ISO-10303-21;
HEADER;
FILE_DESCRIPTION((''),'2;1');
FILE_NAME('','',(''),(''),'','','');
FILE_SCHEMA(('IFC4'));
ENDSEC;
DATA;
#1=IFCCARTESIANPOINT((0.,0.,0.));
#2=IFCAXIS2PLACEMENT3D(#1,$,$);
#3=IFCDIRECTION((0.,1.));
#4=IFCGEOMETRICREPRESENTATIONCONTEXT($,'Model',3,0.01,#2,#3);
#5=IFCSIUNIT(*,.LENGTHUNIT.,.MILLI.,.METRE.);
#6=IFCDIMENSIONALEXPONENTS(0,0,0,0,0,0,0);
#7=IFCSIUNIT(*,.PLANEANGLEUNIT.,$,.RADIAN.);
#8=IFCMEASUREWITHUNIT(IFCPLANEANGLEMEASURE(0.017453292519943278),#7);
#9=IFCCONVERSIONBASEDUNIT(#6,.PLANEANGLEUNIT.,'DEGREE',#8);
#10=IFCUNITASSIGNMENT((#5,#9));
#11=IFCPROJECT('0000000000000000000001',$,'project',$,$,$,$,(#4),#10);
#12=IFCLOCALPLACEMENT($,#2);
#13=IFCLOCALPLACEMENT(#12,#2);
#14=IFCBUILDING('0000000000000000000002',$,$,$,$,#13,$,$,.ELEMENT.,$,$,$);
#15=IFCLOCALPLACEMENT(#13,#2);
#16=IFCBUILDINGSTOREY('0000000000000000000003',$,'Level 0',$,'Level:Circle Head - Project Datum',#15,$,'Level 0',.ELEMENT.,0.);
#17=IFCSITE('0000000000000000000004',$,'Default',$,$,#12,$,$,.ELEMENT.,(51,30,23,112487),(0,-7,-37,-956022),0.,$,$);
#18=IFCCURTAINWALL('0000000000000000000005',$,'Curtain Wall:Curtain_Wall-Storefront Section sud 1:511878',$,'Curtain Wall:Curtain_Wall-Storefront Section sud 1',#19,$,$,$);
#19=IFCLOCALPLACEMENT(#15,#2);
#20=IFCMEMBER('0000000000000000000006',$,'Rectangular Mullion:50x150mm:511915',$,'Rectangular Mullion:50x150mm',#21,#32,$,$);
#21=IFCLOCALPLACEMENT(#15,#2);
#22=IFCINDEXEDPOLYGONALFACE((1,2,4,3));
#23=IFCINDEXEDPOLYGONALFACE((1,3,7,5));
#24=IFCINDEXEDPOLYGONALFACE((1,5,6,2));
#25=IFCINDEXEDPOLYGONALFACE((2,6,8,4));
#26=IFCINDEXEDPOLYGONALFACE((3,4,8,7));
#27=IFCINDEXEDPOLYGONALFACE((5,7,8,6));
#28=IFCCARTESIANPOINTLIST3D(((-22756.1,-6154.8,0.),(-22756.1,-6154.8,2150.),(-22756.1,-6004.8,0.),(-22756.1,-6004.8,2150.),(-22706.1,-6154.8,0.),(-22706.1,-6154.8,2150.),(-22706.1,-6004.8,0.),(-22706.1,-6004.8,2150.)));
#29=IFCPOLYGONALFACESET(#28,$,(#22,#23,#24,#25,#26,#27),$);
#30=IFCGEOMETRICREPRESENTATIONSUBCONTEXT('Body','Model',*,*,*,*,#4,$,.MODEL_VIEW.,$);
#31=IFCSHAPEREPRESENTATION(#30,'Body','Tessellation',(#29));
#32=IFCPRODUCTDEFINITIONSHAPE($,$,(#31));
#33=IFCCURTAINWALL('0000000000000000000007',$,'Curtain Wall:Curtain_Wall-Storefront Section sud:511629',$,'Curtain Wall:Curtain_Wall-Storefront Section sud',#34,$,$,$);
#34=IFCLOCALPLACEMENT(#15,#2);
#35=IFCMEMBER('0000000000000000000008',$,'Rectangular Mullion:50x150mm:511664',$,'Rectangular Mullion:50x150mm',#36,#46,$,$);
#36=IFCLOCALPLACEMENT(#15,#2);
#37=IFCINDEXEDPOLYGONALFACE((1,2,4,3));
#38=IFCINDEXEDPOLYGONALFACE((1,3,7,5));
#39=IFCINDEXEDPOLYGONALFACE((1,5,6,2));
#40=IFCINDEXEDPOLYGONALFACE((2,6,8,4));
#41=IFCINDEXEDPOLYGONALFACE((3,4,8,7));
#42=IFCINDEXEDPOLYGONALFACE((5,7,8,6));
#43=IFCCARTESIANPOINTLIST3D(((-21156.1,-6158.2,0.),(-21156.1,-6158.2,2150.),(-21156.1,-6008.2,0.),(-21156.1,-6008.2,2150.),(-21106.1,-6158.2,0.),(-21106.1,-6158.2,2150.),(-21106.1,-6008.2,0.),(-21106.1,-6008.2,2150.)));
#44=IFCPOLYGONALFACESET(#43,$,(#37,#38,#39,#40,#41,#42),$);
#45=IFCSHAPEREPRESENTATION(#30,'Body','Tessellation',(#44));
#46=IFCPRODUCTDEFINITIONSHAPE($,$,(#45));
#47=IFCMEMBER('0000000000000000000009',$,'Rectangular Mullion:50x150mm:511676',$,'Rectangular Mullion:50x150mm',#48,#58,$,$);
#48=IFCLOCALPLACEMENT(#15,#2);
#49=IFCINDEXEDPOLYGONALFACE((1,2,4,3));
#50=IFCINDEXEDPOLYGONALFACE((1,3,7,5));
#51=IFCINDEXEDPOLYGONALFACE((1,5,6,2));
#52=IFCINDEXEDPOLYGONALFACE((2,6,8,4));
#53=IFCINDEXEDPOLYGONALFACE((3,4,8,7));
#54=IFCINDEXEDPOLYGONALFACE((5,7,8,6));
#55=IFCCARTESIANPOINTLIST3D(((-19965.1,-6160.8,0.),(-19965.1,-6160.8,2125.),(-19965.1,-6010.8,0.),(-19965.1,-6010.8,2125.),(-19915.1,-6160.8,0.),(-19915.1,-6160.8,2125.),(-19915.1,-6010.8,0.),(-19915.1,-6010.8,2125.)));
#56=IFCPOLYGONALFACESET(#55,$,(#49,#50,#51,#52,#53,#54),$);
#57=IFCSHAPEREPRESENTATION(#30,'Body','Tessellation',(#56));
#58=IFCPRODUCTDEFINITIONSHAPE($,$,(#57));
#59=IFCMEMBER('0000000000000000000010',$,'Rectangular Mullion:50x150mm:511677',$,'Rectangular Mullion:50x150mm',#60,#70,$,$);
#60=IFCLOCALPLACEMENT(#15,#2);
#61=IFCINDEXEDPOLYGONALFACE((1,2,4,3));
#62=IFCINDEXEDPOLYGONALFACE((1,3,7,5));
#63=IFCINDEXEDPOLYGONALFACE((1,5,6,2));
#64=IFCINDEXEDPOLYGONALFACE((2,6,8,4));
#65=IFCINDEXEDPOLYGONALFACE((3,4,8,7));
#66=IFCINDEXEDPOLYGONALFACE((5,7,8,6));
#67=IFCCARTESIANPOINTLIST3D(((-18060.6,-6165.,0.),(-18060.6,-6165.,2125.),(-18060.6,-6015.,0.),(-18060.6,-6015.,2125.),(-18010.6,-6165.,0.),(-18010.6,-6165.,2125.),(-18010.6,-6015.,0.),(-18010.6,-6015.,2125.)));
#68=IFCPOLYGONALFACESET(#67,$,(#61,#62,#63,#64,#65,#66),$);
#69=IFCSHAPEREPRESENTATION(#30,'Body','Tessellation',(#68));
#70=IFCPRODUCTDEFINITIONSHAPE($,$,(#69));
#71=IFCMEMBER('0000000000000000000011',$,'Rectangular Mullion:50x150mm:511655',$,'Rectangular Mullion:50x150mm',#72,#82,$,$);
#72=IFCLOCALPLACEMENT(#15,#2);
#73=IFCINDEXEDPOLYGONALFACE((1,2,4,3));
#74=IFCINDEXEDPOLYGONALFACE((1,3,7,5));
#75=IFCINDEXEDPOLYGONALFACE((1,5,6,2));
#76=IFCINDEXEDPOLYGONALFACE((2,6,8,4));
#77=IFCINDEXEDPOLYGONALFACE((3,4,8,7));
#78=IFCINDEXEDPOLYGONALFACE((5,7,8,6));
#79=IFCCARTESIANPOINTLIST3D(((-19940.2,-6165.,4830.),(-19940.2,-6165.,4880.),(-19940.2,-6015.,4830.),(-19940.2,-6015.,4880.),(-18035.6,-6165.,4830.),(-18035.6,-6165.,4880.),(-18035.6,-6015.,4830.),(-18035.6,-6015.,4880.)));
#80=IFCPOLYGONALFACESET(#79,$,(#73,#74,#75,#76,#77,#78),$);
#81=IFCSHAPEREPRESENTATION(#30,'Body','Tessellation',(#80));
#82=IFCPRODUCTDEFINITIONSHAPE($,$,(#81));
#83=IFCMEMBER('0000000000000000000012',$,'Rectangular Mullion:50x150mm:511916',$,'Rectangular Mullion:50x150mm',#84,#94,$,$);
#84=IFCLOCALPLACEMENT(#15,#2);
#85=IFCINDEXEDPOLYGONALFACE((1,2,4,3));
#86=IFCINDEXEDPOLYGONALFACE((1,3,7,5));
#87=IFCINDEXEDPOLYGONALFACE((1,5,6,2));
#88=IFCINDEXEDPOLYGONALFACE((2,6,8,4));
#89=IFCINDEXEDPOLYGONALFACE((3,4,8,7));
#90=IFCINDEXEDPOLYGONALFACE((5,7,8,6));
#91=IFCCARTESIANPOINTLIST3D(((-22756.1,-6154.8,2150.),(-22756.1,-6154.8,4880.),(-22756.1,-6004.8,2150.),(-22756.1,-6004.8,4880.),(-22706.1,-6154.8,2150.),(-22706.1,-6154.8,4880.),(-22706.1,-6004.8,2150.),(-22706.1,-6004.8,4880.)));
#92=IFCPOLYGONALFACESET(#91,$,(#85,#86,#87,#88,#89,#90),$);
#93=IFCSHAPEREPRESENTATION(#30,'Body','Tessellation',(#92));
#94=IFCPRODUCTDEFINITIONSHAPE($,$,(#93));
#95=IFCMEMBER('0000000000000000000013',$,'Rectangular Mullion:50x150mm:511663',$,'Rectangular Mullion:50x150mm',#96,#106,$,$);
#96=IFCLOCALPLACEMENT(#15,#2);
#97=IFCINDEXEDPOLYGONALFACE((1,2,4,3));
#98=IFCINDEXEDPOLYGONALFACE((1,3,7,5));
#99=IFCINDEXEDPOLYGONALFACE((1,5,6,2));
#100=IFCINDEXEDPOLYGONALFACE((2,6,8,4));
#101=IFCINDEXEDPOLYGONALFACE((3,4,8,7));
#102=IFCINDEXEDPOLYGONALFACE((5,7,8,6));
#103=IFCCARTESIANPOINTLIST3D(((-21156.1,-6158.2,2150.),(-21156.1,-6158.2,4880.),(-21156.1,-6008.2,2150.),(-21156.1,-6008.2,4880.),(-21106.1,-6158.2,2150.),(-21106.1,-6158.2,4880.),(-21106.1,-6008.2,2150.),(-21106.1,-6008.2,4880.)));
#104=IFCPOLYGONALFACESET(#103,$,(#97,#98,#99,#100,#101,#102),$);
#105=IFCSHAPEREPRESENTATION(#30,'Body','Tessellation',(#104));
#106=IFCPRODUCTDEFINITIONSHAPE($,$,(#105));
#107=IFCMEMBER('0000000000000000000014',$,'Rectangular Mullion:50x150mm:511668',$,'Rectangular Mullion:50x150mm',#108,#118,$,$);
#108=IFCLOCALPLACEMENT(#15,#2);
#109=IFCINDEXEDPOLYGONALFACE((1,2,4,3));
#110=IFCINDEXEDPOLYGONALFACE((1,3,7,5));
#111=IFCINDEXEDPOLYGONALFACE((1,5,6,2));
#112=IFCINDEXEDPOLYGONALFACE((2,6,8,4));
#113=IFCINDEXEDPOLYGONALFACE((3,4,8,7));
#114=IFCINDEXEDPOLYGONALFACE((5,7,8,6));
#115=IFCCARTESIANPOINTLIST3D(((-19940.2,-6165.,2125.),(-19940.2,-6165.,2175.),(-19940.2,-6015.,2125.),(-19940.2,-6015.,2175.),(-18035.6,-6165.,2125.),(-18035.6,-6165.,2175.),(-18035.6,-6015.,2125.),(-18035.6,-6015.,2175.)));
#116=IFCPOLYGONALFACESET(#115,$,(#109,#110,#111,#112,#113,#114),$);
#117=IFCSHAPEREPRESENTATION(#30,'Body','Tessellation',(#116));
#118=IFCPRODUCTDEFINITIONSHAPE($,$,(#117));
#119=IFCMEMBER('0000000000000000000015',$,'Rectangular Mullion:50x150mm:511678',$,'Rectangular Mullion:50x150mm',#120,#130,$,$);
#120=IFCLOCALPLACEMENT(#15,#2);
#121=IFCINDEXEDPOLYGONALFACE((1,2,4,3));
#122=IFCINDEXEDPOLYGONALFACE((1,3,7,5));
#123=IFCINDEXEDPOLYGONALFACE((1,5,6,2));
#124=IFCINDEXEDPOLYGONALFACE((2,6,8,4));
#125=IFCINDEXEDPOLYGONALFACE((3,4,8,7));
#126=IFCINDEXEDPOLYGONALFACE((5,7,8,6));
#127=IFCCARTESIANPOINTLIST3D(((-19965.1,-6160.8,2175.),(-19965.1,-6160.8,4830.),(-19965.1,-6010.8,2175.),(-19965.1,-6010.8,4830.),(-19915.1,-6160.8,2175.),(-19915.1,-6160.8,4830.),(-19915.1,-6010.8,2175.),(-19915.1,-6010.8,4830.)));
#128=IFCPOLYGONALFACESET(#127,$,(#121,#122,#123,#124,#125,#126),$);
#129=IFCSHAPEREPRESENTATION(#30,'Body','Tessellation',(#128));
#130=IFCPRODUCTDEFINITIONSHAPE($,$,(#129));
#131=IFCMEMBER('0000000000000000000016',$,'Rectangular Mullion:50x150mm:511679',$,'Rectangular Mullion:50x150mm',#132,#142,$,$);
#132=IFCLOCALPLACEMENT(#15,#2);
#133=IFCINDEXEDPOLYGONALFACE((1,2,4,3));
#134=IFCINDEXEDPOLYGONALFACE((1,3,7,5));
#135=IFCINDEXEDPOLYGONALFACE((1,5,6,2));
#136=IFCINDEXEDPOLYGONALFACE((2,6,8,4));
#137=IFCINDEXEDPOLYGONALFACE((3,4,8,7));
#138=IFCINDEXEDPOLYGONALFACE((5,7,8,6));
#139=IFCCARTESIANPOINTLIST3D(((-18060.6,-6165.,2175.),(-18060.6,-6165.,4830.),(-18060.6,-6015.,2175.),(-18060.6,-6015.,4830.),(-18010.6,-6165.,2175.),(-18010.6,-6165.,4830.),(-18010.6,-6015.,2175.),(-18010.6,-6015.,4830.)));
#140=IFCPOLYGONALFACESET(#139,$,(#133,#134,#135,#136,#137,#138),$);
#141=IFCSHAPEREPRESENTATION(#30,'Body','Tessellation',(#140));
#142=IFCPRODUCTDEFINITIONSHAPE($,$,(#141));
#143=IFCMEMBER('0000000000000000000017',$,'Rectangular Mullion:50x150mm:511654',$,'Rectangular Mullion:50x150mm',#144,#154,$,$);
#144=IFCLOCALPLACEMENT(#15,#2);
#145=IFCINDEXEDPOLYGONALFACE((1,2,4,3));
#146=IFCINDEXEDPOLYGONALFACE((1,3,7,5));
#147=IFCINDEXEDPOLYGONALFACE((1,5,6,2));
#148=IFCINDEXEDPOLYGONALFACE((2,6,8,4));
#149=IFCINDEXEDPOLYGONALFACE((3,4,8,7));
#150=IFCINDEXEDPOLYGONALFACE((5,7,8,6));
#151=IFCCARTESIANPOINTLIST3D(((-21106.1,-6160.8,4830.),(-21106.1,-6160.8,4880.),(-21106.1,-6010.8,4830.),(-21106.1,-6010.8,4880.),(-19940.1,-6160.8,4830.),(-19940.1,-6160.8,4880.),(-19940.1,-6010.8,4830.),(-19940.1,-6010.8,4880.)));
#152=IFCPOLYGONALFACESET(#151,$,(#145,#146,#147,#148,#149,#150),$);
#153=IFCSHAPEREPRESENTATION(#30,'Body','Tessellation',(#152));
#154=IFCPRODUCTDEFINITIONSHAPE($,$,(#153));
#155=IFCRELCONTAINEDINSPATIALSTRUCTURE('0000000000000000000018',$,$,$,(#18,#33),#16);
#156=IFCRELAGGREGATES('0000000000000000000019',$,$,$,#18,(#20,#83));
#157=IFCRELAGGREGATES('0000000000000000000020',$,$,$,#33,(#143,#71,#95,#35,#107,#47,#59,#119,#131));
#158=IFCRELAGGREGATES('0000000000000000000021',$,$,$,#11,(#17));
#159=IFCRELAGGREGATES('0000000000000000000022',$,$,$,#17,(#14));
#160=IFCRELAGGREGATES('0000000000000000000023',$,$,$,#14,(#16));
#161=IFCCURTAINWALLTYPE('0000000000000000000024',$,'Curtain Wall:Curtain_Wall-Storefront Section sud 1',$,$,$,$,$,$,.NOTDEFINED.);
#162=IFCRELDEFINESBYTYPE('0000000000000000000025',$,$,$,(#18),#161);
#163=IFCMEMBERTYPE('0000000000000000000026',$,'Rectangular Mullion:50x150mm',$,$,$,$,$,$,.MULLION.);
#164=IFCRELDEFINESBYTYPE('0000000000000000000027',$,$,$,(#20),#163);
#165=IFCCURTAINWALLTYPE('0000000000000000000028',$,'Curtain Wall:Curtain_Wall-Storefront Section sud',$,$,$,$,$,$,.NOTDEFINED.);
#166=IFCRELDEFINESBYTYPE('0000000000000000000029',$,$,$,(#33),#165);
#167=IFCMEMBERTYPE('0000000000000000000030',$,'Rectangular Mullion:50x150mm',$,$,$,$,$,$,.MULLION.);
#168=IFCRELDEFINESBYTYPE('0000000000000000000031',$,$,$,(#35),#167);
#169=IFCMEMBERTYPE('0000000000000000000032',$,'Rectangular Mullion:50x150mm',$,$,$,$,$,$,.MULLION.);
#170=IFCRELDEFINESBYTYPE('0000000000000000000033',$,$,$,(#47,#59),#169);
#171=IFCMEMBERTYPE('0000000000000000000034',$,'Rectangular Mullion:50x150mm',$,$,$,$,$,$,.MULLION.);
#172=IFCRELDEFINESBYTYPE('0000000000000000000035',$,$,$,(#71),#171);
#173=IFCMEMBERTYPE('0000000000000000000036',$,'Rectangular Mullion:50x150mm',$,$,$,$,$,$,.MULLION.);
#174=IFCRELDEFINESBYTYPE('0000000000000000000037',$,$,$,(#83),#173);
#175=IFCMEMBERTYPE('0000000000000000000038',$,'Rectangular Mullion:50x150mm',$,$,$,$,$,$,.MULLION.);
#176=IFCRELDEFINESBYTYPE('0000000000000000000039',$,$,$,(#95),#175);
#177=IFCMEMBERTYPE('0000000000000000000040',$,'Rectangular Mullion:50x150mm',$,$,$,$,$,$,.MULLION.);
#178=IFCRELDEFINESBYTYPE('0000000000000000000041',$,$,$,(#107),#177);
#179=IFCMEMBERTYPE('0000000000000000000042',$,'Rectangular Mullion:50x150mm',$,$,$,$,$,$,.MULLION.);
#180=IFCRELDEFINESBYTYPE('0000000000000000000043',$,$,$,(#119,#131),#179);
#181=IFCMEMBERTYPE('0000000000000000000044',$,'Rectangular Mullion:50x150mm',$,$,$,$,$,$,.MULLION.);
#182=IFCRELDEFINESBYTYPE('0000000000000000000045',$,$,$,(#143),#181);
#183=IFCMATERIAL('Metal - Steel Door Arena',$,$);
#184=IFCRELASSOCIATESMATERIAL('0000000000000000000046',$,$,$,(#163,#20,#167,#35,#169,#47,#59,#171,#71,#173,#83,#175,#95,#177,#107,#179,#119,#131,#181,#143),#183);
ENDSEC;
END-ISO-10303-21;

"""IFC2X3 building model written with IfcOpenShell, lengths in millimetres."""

from ifc_helpers import new_model, entity, si_unit, converted_unit, direction, frame, origin, origin_2d_with_axis, place, context, subcontext, project, spatial, rectangle, extrude, source, transform, mapped, material, type_object, type_shapes, element, aggregate, save


model = new_model("IFC2X3")

# Units and contexts
model_context = context("Model", 3, precision=0.01, world=origin(), true_north=direction((0.0, 1.0)))
body_context = subcontext(model_context, "Body", "Model", "MODEL_VIEW")
ifc_project = project(units=[si_unit("LENGTHUNIT", "METRE", prefix="MILLI"), converted_unit("PLANEANGLEUNIT", "DEGREE", entity("IfcPlaneAngleMeasure", 0.017453292519943278), si_unit("PLANEANGLEUNIT", "RADIAN"), dimensions=[0, 0, 0, 0, 0, 0, 0])], contexts=[model_context])

# Site, building, storey
site_placement = place(None, origin())
site = spatial("IfcSite", under=ifc_project, at=site_placement, Name="Default", CompositionType="ELEMENT", RefLatitude=(51, 30, 23, 112487), RefLongitude=(0, -7, -37, -956022), RefElevation=0.0)
building_placement = place(site_placement, origin())
building = spatial("IfcBuilding", under=site, at=building_placement, CompositionType="ELEMENT")
storey_placement = place(building_placement, origin())
storey = spatial("IfcBuildingStorey", under=building, at=storey_placement, Name="Level 0", ObjectType="Level:Circle Head - Project Datum", LongName="Level 0", CompositionType="ELEMENT", Elevation=0.0)

# Curtain wall, member
curtain_wall_type_1 = type_object("IfcCurtainWallType", Name="Curtain Wall:Curtain_Wall-Storefront Section sud 1", PredefinedType="NOTDEFINED")
curtain_wall_1_placement = place(storey_placement, origin())
curtain_wall_1 = element("IfcCurtainWall", 1, at=curtain_wall_1_placement, inside=storey, type_object=curtain_wall_type_1, Name="Curtain Wall:Curtain_Wall-Storefront Section sud 1:511878", ObjectType="Curtain Wall:Curtain_Wall-Storefront Section sud 1")
ifc_material_1 = material(Name="Metal - Steel Door Arena")
member_type_1 = type_object("IfcMemberType", Name="Rectangular Mullion:50x150mm", PredefinedType="MULLION", material=ifc_material_1)
shared_shape_1 = source(origin(), body_context, "Body", "SweptSolid", [
    extrude(rectangle(XDim=50.0, YDim=150.0, at=origin_2d_with_axis()), frame((-25.0, 0.0, -2150.0), z_axis=(0.0, 0.0, 1.0), x_axis=(-1.0, 0.0, 0.0)), (0.0, 0.0, 1.0), 2150.0),
])
type_shapes(member_type_1, [shared_shape_1])
member_1_placement = place(curtain_wall_1_placement, frame((-22706.1, -6079.8, 0.0), z_axis=(0.0, 0.0, -1.0), x_axis=(1.0, 0.0, 0.0)))
member_1 = element("IfcMember", 2, at=member_1_placement, type_object=member_type_1, material=ifc_material_1, Name="Rectangular Mullion:50x150mm:511915", ObjectType="Rectangular Mullion:50x150mm", context=body_context, shape_type="MappedRepresentation", body=[
    mapped(shared_shape_1, transform((0.0, 0.0, 0.0), scale=1.0)),
])

# Curtain wall, members
curtain_wall_type_2 = type_object("IfcCurtainWallType", Name="Curtain Wall:Curtain_Wall-Storefront Section sud", PredefinedType="NOTDEFINED")
curtain_wall_2_placement = place(storey_placement, origin())
curtain_wall_2 = element("IfcCurtainWall", 3, at=curtain_wall_2_placement, inside=storey, type_object=curtain_wall_type_2, Name="Curtain Wall:Curtain_Wall-Storefront Section sud:511629", ObjectType="Curtain Wall:Curtain_Wall-Storefront Section sud")
member_type_2 = type_object("IfcMemberType", Name="Rectangular Mullion:50x150mm", PredefinedType="MULLION", material=ifc_material_1)
shared_shape_2 = source(origin(), body_context, "Body", "SweptSolid", [
    extrude(rectangle(XDim=50.0, YDim=150.0, at=origin_2d_with_axis()), frame((-25.0, 0.0, -2150.0), z_axis=(0.0, 0.0, 1.0), x_axis=(-1.0, 0.0, 0.0)), (0.0, 0.0, 1.0), 2150.0),
])
type_shapes(member_type_2, [shared_shape_2])
member_2_placement = place(curtain_wall_2_placement, frame((-21156.1, -6083.2, 2150.0), z_axis=(0.0, 0.0, 1.0), x_axis=(-1.0, 0.0, 0.0)))
member_2 = element("IfcMember", 4, at=member_2_placement, type_object=member_type_2, material=ifc_material_1, Name="Rectangular Mullion:50x150mm:511664", ObjectType="Rectangular Mullion:50x150mm", context=body_context, shape_type="MappedRepresentation", body=[
    mapped(shared_shape_2, transform((0.0, 0.0, 0.0), scale=1.0)),
])
member_type_3 = type_object("IfcMemberType", Name="Rectangular Mullion:50x150mm", PredefinedType="MULLION", material=ifc_material_1)
shared_shape_3 = source(origin(), body_context, "Body", "SweptSolid", [
    extrude(rectangle(XDim=50.0, YDim=150.0, at=origin_2d_with_axis()), frame((0.0, 0.0, -2125.0), z_axis=(0.0, 0.0, 1.0), x_axis=(-1.0, 0.0, 0.0)), (0.0, 0.0, 1.0), 2125.0),
])
type_shapes(member_type_3, [shared_shape_3])
member_3_placement = place(curtain_wall_2_placement, frame((-19940.1, -6085.8, 0.0), z_axis=(0.0, 0.0, -1.0), x_axis=(1.0, 0.0, 0.0)))
member_3 = element("IfcMember", 5, at=member_3_placement, type_object=member_type_3, material=ifc_material_1, Name="Rectangular Mullion:50x150mm:511676", ObjectType="Rectangular Mullion:50x150mm", context=body_context, shape_type="MappedRepresentation", body=[
    mapped(shared_shape_3, transform((0.0, 0.0, 0.0), scale=1.0)),
])
member_4_placement = place(curtain_wall_2_placement, frame((-18035.6, -6090.0, 0.0), z_axis=(0.0, 0.0, -1.0), x_axis=(1.0, 0.0, 0.0)))
member_4 = element("IfcMember", 6, at=member_4_placement, type_object=member_type_3, material=ifc_material_1, Name="Rectangular Mullion:50x150mm:511677", ObjectType="Rectangular Mullion:50x150mm", context=body_context, shape_type="MappedRepresentation", body=[
    mapped(shared_shape_3, transform((0.0, 0.0, 0.0), scale=1.0)),
])
member_type_4 = type_object("IfcMemberType", Name="Rectangular Mullion:50x150mm", PredefinedType="MULLION", material=ifc_material_1)
shared_shape_4 = source(origin(), body_context, "Body", "SweptSolid", [
    extrude(rectangle(XDim=50.0, YDim=150.0, at=origin_2d_with_axis()), frame((-25.0, 0.0, -1904.5), z_axis=(0.0, 0.0, 1.0), x_axis=(-1.0, 0.0, 0.0)), (0.0, 0.0, 1.0), 1904.5),
])
type_shapes(member_type_4, [shared_shape_4])
member_5_placement = place(curtain_wall_2_placement, frame((-18035.6, -6090.0, 4880.0), z_axis=(1.0, 0.0, 0.0), x_axis=(0.0, 0.0, 1.0)))
member_5 = element("IfcMember", 7, at=member_5_placement, type_object=member_type_4, material=ifc_material_1, Name="Rectangular Mullion:50x150mm:511655", ObjectType="Rectangular Mullion:50x150mm", context=body_context, shape_type="MappedRepresentation", body=[
    mapped(shared_shape_4, transform((0.0, 0.0, 0.0), scale=1.0)),
])

# Members
member_type_5 = type_object("IfcMemberType", Name="Rectangular Mullion:50x150mm", PredefinedType="MULLION", material=ifc_material_1)
shared_shape_5 = source(origin(), body_context, "Body", "SweptSolid", [
    extrude(rectangle(XDim=50.0, YDim=150.0, at=origin_2d_with_axis()), frame((-25.0, 0.0, -2730.0), z_axis=(0.0, 0.0, 1.0), x_axis=(-1.0, 0.0, 0.0)), (0.0, 0.0, 1.0), 2730.0),
])
type_shapes(member_type_5, [shared_shape_5])
member_6_placement = place(curtain_wall_1_placement, frame((-22706.1, -6079.8, 2150.0), z_axis=(0.0, 0.0, -1.0), x_axis=(1.0, 0.0, 0.0)))
member_6 = element("IfcMember", 8, at=member_6_placement, type_object=member_type_5, material=ifc_material_1, Name="Rectangular Mullion:50x150mm:511916", ObjectType="Rectangular Mullion:50x150mm", context=body_context, shape_type="MappedRepresentation", body=[
    mapped(shared_shape_5, transform((0.0, 0.0, 0.0), scale=1.0)),
])
member_type_6 = type_object("IfcMemberType", Name="Rectangular Mullion:50x150mm", PredefinedType="MULLION", material=ifc_material_1)
shared_shape_6 = source(origin(), body_context, "Body", "SweptSolid", [
    extrude(rectangle(XDim=50.0, YDim=150.0, at=origin_2d_with_axis()), frame((-25.0, 0.0, -2730.0), z_axis=(0.0, 0.0, 1.0), x_axis=(-1.0, 0.0, 0.0)), (0.0, 0.0, 1.0), 2730.0),
])
type_shapes(member_type_6, [shared_shape_6])
member_7_placement = place(curtain_wall_2_placement, frame((-21156.1, -6083.2, 4880.0), z_axis=(0.0, 0.0, 1.0), x_axis=(-1.0, 0.0, 0.0)))
member_7 = element("IfcMember", 9, at=member_7_placement, type_object=member_type_6, material=ifc_material_1, Name="Rectangular Mullion:50x150mm:511663", ObjectType="Rectangular Mullion:50x150mm", context=body_context, shape_type="MappedRepresentation", body=[
    mapped(shared_shape_6, transform((0.0, 0.0, 0.0), scale=1.0)),
])
member_type_7 = type_object("IfcMemberType", Name="Rectangular Mullion:50x150mm", PredefinedType="MULLION", material=ifc_material_1)
shared_shape_7 = source(origin(), body_context, "Body", "SweptSolid", [
    extrude(rectangle(XDim=50.0, YDim=150.0, at=origin_2d_with_axis()), frame((0.0, 0.0, -1904.5), z_axis=(0.0, 0.0, 1.0), x_axis=(-1.0, 0.0, 0.0)), (0.0, 0.0, 1.0), 1904.5),
])
type_shapes(member_type_7, [shared_shape_7])
member_8_placement = place(curtain_wall_2_placement, frame((-18035.6, -6090.0, 2150.0), z_axis=(1.0, 0.0, 0.0), x_axis=(0.0, 0.0, 1.0)))
member_8 = element("IfcMember", 10, at=member_8_placement, type_object=member_type_7, material=ifc_material_1, Name="Rectangular Mullion:50x150mm:511668", ObjectType="Rectangular Mullion:50x150mm", context=body_context, shape_type="MappedRepresentation", body=[
    mapped(shared_shape_7, transform((0.0, 0.0, 0.0), scale=1.0)),
])
member_type_8 = type_object("IfcMemberType", Name="Rectangular Mullion:50x150mm", PredefinedType="MULLION", material=ifc_material_1)
shared_shape_8 = source(origin(), body_context, "Body", "SweptSolid", [
    extrude(rectangle(XDim=50.0, YDim=150.0, at=origin_2d_with_axis()), frame((0.0, 0.0, -2655.0), z_axis=(0.0, 0.0, 1.0), x_axis=(-1.0, 0.0, 0.0)), (0.0, 0.0, 1.0), 2655.0),
])
type_shapes(member_type_8, [shared_shape_8])
member_9_placement = place(curtain_wall_2_placement, frame((-19940.1, -6085.8, 2175.0), z_axis=(0.0, 0.0, -1.0), x_axis=(1.0, 0.0, 0.0)))
member_9 = element("IfcMember", 11, at=member_9_placement, type_object=member_type_8, material=ifc_material_1, Name="Rectangular Mullion:50x150mm:511678", ObjectType="Rectangular Mullion:50x150mm", context=body_context, shape_type="MappedRepresentation", body=[
    mapped(shared_shape_8, transform((0.0, 0.0, 0.0), scale=1.0)),
])
member_10_placement = place(curtain_wall_2_placement, frame((-18035.6, -6090.0, 2175.0), z_axis=(0.0, 0.0, -1.0), x_axis=(1.0, 0.0, 0.0)))
member_10 = element("IfcMember", 12, at=member_10_placement, type_object=member_type_8, material=ifc_material_1, Name="Rectangular Mullion:50x150mm:511679", ObjectType="Rectangular Mullion:50x150mm", context=body_context, shape_type="MappedRepresentation", body=[
    mapped(shared_shape_8, transform((0.0, 0.0, 0.0), scale=1.0)),
])
member_type_9 = type_object("IfcMemberType", Name="Rectangular Mullion:50x150mm", PredefinedType="MULLION", material=ifc_material_1)
shared_shape_9 = source(origin(), body_context, "Body", "SweptSolid", [
    extrude(rectangle(XDim=50.0, YDim=150.0, at=origin_2d_with_axis()), frame((-25.0, 0.0, -1166.0), z_axis=(0.0, 0.0, 1.0), x_axis=(-1.0, 0.0, 0.0)), (0.0, 0.0, 1.0), 1166.0),
])
type_shapes(member_type_9, [shared_shape_9])
member_11_placement = place(curtain_wall_2_placement, frame((-19940.1, -6085.8, 4880.0), z_axis=(1.0, 0.0, 0.0), x_axis=(0.0, 0.0, 1.0)))
member_11 = element("IfcMember", 13, at=member_11_placement, type_object=member_type_9, material=ifc_material_1, Name="Rectangular Mullion:50x150mm:511654", ObjectType="Rectangular Mullion:50x150mm", context=body_context, shape_type="MappedRepresentation", body=[
    mapped(shared_shape_9, transform((0.0, 0.0, 0.0), scale=1.0)),
])
aggregate(curtain_wall_1, [member_1, member_6])

aggregate(curtain_wall_2, [member_11, member_5, member_7, member_2, member_8, member_3, member_4, member_9, member_10])

save(model, "model.ifc")
